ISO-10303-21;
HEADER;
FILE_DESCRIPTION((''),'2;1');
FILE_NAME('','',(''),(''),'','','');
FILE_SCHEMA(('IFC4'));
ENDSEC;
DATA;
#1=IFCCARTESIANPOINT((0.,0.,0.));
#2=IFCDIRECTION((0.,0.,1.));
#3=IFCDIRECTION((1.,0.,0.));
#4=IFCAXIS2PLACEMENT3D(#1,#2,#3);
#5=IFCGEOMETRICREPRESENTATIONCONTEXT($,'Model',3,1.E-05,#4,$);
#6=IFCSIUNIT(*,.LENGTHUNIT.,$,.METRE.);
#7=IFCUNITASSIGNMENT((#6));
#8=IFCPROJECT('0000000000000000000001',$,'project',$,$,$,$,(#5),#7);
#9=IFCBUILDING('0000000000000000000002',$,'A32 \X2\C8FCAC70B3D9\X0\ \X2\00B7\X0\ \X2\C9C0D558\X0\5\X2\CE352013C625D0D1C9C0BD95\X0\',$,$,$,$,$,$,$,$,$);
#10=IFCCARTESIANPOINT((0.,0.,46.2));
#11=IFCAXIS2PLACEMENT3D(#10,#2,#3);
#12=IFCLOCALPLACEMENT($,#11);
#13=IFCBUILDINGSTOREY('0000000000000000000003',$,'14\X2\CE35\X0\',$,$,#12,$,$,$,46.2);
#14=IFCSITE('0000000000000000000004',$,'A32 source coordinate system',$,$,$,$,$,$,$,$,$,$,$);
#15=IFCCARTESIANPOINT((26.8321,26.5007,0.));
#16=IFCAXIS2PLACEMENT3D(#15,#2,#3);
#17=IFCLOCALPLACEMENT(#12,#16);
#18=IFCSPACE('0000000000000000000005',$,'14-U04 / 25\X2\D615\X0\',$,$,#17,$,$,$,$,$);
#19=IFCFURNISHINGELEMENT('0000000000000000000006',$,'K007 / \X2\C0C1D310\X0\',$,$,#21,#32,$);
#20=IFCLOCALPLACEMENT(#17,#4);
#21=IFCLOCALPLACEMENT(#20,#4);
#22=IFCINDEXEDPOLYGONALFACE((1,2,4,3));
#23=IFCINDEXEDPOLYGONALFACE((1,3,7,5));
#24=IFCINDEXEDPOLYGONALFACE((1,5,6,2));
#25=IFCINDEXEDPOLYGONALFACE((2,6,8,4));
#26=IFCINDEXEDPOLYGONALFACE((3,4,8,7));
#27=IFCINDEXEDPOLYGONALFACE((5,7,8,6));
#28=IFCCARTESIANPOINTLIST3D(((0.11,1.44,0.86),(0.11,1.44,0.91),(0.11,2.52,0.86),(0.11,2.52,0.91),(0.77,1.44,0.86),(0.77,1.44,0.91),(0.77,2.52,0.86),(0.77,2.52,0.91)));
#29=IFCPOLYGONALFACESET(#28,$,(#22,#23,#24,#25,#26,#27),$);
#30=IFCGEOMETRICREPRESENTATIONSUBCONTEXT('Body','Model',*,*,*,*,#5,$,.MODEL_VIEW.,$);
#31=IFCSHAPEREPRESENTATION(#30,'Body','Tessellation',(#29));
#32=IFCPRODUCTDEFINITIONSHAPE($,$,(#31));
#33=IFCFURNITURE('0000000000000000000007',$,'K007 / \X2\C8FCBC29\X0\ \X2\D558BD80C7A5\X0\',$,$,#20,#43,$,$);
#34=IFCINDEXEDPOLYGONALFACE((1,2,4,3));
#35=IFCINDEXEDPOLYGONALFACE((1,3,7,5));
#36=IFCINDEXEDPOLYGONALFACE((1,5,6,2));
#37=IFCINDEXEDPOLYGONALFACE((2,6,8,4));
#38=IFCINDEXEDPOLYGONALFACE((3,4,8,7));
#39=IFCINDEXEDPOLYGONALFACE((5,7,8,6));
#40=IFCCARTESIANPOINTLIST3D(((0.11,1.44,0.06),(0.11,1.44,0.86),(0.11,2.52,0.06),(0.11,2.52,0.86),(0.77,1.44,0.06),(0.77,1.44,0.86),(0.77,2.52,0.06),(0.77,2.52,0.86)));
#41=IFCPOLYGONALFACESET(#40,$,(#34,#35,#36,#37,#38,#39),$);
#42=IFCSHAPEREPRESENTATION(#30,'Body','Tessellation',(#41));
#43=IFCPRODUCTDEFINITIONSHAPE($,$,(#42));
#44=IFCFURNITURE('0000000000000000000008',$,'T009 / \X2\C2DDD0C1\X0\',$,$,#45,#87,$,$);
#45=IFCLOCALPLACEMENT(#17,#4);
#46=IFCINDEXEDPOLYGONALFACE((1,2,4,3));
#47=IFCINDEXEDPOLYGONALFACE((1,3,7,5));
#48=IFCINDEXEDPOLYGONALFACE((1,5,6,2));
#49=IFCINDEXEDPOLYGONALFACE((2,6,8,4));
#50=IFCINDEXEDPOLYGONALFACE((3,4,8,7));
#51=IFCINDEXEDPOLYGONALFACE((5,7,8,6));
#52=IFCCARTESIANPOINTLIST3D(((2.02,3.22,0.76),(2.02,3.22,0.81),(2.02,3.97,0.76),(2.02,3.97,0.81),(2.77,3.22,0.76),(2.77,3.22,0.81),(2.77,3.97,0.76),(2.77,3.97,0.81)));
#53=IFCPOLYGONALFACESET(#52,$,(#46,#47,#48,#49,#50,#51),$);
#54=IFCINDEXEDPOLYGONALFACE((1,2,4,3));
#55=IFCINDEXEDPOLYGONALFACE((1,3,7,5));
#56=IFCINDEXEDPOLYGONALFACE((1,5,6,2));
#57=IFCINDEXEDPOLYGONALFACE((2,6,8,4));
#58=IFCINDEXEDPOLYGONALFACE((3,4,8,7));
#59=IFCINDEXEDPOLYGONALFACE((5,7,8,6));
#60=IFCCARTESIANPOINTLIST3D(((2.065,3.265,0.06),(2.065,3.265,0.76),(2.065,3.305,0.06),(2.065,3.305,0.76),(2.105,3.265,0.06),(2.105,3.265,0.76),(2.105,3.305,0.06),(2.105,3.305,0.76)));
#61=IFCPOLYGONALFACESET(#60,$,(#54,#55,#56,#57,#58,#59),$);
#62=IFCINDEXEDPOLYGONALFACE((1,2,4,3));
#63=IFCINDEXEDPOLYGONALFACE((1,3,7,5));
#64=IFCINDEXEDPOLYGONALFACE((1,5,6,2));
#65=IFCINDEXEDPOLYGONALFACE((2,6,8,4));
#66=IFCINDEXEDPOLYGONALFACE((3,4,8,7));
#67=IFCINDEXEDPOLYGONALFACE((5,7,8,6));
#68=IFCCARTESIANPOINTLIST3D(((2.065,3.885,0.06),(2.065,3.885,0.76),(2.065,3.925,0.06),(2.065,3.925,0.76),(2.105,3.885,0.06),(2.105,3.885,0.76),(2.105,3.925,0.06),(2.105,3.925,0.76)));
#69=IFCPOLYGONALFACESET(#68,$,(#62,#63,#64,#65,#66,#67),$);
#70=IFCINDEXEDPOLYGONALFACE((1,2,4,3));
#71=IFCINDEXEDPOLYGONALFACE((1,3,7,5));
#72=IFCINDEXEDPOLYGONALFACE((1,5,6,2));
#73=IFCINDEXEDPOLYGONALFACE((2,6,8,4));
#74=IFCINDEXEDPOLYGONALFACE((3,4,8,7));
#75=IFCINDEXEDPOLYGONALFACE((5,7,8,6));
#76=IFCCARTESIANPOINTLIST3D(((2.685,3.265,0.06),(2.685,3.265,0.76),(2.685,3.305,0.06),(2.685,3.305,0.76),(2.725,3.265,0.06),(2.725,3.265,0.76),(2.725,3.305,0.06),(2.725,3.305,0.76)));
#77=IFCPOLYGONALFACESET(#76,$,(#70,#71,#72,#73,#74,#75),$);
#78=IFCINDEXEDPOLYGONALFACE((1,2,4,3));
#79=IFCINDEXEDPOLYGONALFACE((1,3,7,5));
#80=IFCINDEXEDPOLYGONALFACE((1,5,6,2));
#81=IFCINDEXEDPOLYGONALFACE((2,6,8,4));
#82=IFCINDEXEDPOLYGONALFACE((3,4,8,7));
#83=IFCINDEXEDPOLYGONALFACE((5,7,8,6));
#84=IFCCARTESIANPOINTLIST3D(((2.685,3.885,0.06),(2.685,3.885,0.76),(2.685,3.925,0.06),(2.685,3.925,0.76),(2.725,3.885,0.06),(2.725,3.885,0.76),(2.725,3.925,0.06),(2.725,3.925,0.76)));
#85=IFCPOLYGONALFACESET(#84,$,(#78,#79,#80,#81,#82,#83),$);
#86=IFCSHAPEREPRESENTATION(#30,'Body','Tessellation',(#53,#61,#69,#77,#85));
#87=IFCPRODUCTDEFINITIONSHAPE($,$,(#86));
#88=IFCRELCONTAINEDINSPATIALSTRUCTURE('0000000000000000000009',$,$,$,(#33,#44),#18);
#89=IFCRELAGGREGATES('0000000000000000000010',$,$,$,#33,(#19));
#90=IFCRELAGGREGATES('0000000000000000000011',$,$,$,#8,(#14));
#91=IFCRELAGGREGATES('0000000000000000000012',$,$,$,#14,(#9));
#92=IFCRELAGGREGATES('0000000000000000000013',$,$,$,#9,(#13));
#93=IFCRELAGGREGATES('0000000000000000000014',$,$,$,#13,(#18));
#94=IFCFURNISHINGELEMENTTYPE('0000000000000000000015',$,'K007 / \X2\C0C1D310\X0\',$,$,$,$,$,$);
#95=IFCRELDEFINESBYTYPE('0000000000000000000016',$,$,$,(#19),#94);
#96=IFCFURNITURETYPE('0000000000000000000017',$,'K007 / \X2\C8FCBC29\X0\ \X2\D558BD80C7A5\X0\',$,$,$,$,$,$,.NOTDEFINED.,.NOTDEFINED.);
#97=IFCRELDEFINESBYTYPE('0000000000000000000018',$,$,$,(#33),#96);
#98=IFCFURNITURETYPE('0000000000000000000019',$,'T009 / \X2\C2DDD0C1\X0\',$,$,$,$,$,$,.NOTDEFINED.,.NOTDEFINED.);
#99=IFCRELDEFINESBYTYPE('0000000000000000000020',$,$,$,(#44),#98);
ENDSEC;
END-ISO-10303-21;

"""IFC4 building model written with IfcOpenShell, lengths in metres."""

from ifc_helpers import new_model, si_unit, frame, origin, origin_with_axes, place, context, subcontext, project, spatial, polyline, outline, extrude, source, transform, mapped, type_object, type_shapes, element, aggregate, save


model = new_model("IFC4")

# Units and contexts
model_context = context("Model", 3, precision=1e-05, world=origin_with_axes())
body_context = subcontext(model_context, "Body", "Model", "MODEL_VIEW")
ifc_project = project(units=[si_unit("LENGTHUNIT", "METRE")], contexts=[model_context])

# Site, building, storey
site = spatial("IfcSite", under=ifc_project, Name="A32 source coordinate system")
building = spatial("IfcBuilding", under=site, Name="A32 주거동 · 지하5층–옥탑지붕")
storey_placement = place(None, frame((0.0, 0.0, 46.2), z_axis=(0.0, 0.0, 1.0), x_axis=(1.0, 0.0, 0.0)))
storey = spatial("IfcBuildingStorey", under=building, at=storey_placement, Name="14층", Elevation=46.2)

# Shared definitions
space_1_placement = place(storey_placement, frame((26.8321, 26.5007, 0.0), z_axis=(0.0, 0.0, 1.0), x_axis=(1.0, 0.0, 0.0)))
space_1 = spatial("IfcSpace", under=storey, at=space_1_placement, Name="14-U04 / 25형")

# Furnishing element
furnishing_element_type_1 = type_object("IfcFurnishingElementType", Name="K007 / 상판")
shared_shape_1 = source(origin(), body_context, "Body", "SweptSolid", [
    extrude(outline(polyline([(0.77, 2.52), (0.77, 1.44), (0.11, 1.44), (0.11, 2.52), (0.77, 2.52)])), frame((0.0, 0.0, 0.86)), (0.0, 0.0, 1.0), 0.05),
])
type_shapes(furnishing_element_type_1, [shared_shape_1])
furniture_1_placement = place(space_1_placement, origin_with_axes())
furnishing_1_placement = place(furniture_1_placement, origin_with_axes())
furnishing_1 = element("IfcFurnishingElement", 1, at=furnishing_1_placement, type_object=furnishing_element_type_1, Name="K007 / 상판", context=body_context, shape_type="MappedRepresentation", body=[
    mapped(shared_shape_1, transform((0.0, 0.0, 0.0), scale=1.0)),
])

# Furniture
furniture_type_1 = type_object("IfcFurnitureType", Name="K007 / 주방 하부장", AssemblyPlace="NOTDEFINED", PredefinedType="NOTDEFINED")
shared_shape_2 = source(origin(), body_context, "Body", "SweptSolid", [
    extrude(outline(polyline([(0.11, 2.52), (0.77, 2.52), (0.77, 1.44), (0.11, 1.44), (0.11, 2.52)])), frame((0.0, 0.0, 0.06)), (0.0, 0.0, 1.0), 0.8),
])
type_shapes(furniture_type_1, [shared_shape_2])
furniture_1 = element("IfcFurniture", 2, at=furniture_1_placement, inside=space_1, type_object=furniture_type_1, Name="K007 / 주방 하부장", context=body_context, shape_type="MappedRepresentation", body=[
    mapped(shared_shape_2, transform((0.0, 0.0, 0.0), scale=1.0)),
])
aggregate(furniture_1, [furnishing_1])
furniture_type_2 = type_object("IfcFurnitureType", Name="T009 / 식탁", AssemblyPlace="NOTDEFINED", PredefinedType="NOTDEFINED")
shared_shape_3 = source(origin(), body_context, "Body", "SweptSolid", [
    extrude(outline(polyline([(2.77, 3.22), (2.02, 3.22), (2.02, 3.97), (2.77, 3.97), (2.77, 3.22)])), frame((0.0, 0.0, 0.76)), (0.0, 0.0, 1.0), 0.05),
    extrude(outline(polyline([(2.065, 3.265), (2.065, 3.305), (2.105, 3.305), (2.105, 3.265), (2.065, 3.265)])), frame((0.0, 0.0, 0.06)), (0.0, 0.0, 1.0), 0.7),
    extrude(outline(polyline([(2.065, 3.885), (2.065, 3.925), (2.105, 3.925), (2.105, 3.885), (2.065, 3.885)])), frame((0.0, 0.0, 0.06)), (0.0, 0.0, 1.0), 0.7),
    extrude(outline(polyline([(2.685, 3.265), (2.685, 3.305), (2.725, 3.305), (2.725, 3.265), (2.685, 3.265)])), frame((0.0, 0.0, 0.06)), (0.0, 0.0, 1.0), 0.7),
    extrude(outline(polyline([(2.685, 3.885), (2.685, 3.925), (2.725, 3.925), (2.725, 3.885), (2.685, 3.885)])), frame((0.0, 0.0, 0.06)), (0.0, 0.0, 1.0), 0.7),
])
type_shapes(furniture_type_2, [shared_shape_3])
furniture_2_placement = place(space_1_placement, origin_with_axes())
element("IfcFurniture", 3, at=furniture_2_placement, inside=space_1, type_object=furniture_type_2, Name="T009 / 식탁", context=body_context, shape_type="MappedRepresentation", body=[
    mapped(shared_shape_3, transform((0.0, 0.0, 0.0), scale=1.0)),
])

save(model, "model.ifc")
